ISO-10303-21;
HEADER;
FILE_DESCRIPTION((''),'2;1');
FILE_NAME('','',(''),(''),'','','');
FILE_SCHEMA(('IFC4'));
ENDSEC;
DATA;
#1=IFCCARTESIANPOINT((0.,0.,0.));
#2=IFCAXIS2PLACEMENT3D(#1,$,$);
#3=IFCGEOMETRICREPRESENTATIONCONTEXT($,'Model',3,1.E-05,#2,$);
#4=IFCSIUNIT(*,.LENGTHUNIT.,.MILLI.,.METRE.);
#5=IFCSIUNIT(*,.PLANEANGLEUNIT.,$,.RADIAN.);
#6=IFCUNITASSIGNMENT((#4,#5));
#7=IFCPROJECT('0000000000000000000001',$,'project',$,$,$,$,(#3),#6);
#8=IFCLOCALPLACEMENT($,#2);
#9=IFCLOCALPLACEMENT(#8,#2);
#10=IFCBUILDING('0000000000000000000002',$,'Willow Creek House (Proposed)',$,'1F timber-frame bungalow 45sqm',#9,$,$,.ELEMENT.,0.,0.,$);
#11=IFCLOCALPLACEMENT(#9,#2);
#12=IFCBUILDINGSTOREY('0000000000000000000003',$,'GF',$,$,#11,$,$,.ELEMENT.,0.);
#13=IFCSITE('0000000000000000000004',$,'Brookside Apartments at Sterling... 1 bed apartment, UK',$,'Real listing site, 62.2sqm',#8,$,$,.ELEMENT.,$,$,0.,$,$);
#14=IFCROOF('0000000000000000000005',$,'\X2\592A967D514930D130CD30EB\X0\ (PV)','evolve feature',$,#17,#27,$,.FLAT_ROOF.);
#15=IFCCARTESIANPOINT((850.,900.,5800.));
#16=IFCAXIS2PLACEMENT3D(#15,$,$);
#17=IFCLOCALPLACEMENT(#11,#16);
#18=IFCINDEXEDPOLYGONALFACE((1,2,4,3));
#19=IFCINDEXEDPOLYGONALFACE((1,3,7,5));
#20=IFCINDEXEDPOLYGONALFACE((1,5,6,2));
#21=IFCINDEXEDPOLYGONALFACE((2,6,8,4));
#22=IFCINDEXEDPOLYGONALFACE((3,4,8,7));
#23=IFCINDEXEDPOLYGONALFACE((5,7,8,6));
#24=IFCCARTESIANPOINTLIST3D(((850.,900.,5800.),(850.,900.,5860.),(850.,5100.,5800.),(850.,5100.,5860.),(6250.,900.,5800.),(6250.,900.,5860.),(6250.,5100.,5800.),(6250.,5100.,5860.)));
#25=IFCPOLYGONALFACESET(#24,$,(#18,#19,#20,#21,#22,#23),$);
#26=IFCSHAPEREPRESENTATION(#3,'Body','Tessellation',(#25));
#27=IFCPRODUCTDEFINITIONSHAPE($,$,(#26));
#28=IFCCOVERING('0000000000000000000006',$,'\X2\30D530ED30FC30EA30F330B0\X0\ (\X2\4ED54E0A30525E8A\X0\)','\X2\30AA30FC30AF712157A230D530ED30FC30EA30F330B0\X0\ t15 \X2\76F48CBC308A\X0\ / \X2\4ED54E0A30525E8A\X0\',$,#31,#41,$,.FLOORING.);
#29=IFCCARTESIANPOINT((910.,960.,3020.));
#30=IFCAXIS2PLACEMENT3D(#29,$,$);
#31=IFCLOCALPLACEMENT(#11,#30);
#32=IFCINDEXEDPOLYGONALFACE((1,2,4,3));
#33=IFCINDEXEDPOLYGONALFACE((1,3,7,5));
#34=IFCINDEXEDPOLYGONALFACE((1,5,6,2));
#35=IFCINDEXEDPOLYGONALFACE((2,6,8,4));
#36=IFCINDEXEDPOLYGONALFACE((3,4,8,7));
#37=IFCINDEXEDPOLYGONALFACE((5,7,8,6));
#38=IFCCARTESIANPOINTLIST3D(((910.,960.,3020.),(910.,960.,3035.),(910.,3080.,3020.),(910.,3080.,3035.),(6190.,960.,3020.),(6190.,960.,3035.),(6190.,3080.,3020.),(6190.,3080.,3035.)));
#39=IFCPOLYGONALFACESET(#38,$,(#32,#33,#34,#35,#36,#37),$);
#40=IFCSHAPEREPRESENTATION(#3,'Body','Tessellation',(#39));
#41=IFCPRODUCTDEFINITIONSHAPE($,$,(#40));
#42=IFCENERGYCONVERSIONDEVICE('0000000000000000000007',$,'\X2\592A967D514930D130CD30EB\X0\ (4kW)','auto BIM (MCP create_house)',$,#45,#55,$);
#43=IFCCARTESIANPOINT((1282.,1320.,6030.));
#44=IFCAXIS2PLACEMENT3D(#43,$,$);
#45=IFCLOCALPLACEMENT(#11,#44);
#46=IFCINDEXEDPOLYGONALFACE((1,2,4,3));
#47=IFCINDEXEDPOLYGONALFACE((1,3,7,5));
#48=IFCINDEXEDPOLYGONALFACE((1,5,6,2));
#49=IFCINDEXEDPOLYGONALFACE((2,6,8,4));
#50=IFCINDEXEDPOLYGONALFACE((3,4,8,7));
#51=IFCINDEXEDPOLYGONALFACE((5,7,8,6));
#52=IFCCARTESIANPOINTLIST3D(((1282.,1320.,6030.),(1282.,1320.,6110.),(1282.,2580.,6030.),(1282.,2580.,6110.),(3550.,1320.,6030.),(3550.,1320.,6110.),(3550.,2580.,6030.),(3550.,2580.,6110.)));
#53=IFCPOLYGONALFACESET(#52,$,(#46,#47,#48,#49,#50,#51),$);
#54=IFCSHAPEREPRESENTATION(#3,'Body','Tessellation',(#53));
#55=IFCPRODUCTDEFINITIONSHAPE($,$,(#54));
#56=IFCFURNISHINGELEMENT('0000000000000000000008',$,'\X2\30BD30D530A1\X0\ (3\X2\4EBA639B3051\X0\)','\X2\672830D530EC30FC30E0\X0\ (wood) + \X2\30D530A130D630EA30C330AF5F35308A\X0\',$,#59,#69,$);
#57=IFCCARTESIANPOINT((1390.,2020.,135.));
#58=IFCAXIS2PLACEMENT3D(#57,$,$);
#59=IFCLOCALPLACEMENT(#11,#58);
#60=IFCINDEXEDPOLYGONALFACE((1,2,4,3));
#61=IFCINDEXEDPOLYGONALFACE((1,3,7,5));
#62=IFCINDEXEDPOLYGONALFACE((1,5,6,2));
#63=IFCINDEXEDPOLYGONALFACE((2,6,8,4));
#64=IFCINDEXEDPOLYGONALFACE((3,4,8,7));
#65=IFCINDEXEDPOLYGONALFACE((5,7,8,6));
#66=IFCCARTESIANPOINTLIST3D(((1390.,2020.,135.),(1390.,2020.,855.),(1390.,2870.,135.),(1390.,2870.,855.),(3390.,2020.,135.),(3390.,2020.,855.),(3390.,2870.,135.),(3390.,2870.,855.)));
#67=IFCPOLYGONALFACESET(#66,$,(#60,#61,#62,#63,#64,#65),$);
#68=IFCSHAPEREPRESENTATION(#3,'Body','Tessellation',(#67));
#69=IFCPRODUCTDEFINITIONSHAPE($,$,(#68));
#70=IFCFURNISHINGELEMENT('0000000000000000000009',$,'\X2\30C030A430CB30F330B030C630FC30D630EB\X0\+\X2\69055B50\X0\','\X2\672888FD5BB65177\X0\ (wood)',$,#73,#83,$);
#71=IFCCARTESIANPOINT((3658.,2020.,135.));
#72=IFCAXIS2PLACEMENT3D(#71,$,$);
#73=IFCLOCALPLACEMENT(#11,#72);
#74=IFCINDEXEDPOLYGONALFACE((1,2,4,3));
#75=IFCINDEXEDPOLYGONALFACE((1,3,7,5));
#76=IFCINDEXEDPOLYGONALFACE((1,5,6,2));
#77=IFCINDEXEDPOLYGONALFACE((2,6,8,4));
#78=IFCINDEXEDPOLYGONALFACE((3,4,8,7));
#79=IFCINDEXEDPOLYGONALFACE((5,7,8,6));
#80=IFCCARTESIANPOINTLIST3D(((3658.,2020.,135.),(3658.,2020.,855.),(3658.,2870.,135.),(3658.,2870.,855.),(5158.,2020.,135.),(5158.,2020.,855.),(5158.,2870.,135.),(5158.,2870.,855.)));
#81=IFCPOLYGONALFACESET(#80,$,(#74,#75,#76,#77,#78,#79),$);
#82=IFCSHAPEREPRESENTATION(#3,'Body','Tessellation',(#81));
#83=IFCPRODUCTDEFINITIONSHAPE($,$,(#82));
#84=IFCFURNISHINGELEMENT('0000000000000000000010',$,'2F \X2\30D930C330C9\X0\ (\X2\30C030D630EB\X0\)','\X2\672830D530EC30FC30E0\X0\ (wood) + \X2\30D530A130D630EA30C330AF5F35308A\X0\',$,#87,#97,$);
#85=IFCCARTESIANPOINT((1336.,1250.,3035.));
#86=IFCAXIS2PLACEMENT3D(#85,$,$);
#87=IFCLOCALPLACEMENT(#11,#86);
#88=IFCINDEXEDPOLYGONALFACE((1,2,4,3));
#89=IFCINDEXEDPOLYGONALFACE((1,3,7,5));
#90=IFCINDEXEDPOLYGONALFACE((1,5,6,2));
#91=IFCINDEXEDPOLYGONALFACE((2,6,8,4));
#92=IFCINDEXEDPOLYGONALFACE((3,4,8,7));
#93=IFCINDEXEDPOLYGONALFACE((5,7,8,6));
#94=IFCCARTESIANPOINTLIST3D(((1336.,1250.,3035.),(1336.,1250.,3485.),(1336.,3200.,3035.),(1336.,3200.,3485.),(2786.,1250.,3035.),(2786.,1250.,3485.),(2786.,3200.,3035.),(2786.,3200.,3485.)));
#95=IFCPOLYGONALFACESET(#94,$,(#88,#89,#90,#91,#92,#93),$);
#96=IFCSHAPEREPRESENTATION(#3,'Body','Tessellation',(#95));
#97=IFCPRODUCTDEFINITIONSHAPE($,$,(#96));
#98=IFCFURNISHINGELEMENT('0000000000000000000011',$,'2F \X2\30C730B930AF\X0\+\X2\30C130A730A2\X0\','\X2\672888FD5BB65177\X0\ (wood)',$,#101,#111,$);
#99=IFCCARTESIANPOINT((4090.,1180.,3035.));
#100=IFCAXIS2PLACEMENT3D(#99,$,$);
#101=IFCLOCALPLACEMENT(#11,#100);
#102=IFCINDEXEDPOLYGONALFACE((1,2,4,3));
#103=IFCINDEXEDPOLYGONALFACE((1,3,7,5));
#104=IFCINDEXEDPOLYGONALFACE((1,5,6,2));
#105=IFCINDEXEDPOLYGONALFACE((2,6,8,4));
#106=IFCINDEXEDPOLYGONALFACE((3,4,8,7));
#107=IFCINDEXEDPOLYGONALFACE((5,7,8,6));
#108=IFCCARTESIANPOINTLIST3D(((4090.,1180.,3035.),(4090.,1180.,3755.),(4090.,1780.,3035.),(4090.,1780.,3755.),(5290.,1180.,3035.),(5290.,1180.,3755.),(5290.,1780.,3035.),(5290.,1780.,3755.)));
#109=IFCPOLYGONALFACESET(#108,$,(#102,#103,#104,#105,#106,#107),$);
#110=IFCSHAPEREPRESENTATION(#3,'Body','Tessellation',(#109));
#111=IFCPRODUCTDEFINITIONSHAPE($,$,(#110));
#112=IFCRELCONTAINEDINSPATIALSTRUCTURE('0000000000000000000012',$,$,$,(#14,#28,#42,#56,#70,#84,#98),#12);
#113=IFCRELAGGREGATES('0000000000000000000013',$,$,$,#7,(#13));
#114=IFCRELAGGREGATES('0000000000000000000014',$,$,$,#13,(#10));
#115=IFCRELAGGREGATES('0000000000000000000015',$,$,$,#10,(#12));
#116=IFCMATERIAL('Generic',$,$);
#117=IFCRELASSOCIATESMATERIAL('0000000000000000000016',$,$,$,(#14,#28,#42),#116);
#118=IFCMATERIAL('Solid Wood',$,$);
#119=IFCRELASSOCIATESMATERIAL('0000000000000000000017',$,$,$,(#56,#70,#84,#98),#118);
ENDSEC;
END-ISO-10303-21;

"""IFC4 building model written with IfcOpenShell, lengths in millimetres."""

from ifc_helpers import new_model, si_unit, frame, frame_2d, origin, place, context, project, spatial, rectangle, extrude, material, element, save


model = new_model("IFC4")

# Units and contexts
model_context = context("Model", 3, precision=1e-05, world=origin())
ifc_project = project(units=[si_unit("LENGTHUNIT", "METRE", prefix="MILLI"), si_unit("PLANEANGLEUNIT", "RADIAN")], contexts=[model_context])

# Site, building, storey
site_placement = place(None, origin())
site = spatial("IfcSite", under=ifc_project, at=site_placement, Name="Brookside Apartments at Sterling... 1 bed apartment, UK", ObjectType="Real listing site, 62.2sqm", CompositionType="ELEMENT", RefElevation=0.0)
building_placement = place(site_placement, origin())
building = spatial("IfcBuilding", under=site, at=building_placement, Name="Willow Creek House (Proposed)", ObjectType="1F timber-frame bungalow 45sqm", CompositionType="ELEMENT", ElevationOfRefHeight=0.0, ElevationOfTerrain=0.0)
storey_placement = place(building_placement, origin())
storey = spatial("IfcBuildingStorey", under=building, at=storey_placement, Name="GF", CompositionType="ELEMENT", Elevation=0.0)

# Shared definitions
ifc_material_1 = material(Name="Solid Wood")

# Roof
ifc_material_2 = material(Name="Generic")
roof_1_placement = place(storey_placement, frame((850.0, 900.0, 5800.0)))
element("IfcRoof", 1, at=roof_1_placement, inside=storey, material=ifc_material_2, Name="太陽光パネル (PV)", Description="evolve feature", PredefinedType="FLAT_ROOF", context=model_context, shape_type="SweptSolid", body=[
    extrude(rectangle(XDim=5400.0, YDim=4200.0, at=frame_2d((2700.0, 2100.0))), frame((850.0, 900.0, 5800.0)), (0.0, 0.0, 1.0), 60.0),
])

# Covering
covering_placement = place(storey_placement, frame((910.0, 960.0, 3020.0)))
element("IfcCovering", 2, at=covering_placement, inside=storey, material=ifc_material_2, Name="フローリング (仕上げ床)", Description="オーク無垢フローリング t15 直貼り / 仕上げ床", PredefinedType="FLOORING", context=model_context, shape_type="SweptSolid", body=[
    extrude(rectangle(XDim=5280.0, YDim=2120.0, at=frame_2d((2640.0, 1060.0))), frame((910.0, 960.0, 3020.0)), (0.0, 0.0, 1.0), 15.0),
])

# Energy conversion device
energy_conversion_device_placement = place(storey_placement, frame((1282.0, 1320.0, 6030.0)))
element("IfcEnergyConversionDevice", 3, at=energy_conversion_device_placement, inside=storey, material=ifc_material_2, Name="太陽光パネル (4kW)", Description="auto BIM (MCP create_house)", context=model_context, shape_type="SweptSolid", body=[
    extrude(rectangle(XDim=2268.0, YDim=1260.0, at=frame_2d((1134.0, 630.0))), frame((1282.0, 1320.0, 6030.0)), (0.0, 0.0, 1.0), 80.0),
])

# Furnishing elements
furnishing_1_placement = place(storey_placement, frame((1390.0, 2020.0, 135.0)))
element("IfcFurnishingElement", 4, at=furnishing_1_placement, inside=storey, material=ifc_material_1, Name="ソファ (3人掛け)", Description="木フレーム (wood) + ファブリック張り", context=model_context, shape_type="SweptSolid", body=[
    extrude(rectangle(XDim=2000.0, YDim=850.0, at=frame_2d((1000.0, 425.0))), frame((1390.0, 2020.0, 135.0)), (0.0, 0.0, 1.0), 720.0),
])
furnishing_2_placement = place(storey_placement, frame((3658.0, 2020.0, 135.0)))
element("IfcFurnishingElement", 5, at=furnishing_2_placement, inside=storey, material=ifc_material_1, Name="ダイニングテーブル+椅子", Description="木製家具 (wood)", context=model_context, shape_type="SweptSolid", body=[
    extrude(rectangle(XDim=1500.0, YDim=850.0, at=frame_2d((750.0, 425.0))), frame((3658.0, 2020.0, 135.0)), (0.0, 0.0, 1.0), 720.0),
])
furnishing_3_placement = place(storey_placement, frame((1336.0, 1250.0, 3035.0)))
element("IfcFurnishingElement", 6, at=furnishing_3_placement, inside=storey, material=ifc_material_1, Name="2F ベッド (ダブル)", Description="木フレーム (wood) + ファブリック張り", context=model_context, shape_type="SweptSolid", body=[
    extrude(rectangle(XDim=1450.0, YDim=1950.0, at=frame_2d((725.0, 975.0))), frame((1336.0, 1250.0, 3035.0)), (0.0, 0.0, 1.0), 450.0),
])
furnishing_4_placement = place(storey_placement, frame((4090.0, 1180.0, 3035.0)))
element("IfcFurnishingElement", 7, at=furnishing_4_placement, inside=storey, material=ifc_material_1, Name="2F デスク+チェア", Description="木製家具 (wood)", context=model_context, shape_type="SweptSolid", body=[
    extrude(rectangle(XDim=1200.0, YDim=600.0, at=frame_2d((600.0, 300.0))), frame((4090.0, 1180.0, 3035.0)), (0.0, 0.0, 1.0), 720.0),
])

save(model, "model.ifc")
